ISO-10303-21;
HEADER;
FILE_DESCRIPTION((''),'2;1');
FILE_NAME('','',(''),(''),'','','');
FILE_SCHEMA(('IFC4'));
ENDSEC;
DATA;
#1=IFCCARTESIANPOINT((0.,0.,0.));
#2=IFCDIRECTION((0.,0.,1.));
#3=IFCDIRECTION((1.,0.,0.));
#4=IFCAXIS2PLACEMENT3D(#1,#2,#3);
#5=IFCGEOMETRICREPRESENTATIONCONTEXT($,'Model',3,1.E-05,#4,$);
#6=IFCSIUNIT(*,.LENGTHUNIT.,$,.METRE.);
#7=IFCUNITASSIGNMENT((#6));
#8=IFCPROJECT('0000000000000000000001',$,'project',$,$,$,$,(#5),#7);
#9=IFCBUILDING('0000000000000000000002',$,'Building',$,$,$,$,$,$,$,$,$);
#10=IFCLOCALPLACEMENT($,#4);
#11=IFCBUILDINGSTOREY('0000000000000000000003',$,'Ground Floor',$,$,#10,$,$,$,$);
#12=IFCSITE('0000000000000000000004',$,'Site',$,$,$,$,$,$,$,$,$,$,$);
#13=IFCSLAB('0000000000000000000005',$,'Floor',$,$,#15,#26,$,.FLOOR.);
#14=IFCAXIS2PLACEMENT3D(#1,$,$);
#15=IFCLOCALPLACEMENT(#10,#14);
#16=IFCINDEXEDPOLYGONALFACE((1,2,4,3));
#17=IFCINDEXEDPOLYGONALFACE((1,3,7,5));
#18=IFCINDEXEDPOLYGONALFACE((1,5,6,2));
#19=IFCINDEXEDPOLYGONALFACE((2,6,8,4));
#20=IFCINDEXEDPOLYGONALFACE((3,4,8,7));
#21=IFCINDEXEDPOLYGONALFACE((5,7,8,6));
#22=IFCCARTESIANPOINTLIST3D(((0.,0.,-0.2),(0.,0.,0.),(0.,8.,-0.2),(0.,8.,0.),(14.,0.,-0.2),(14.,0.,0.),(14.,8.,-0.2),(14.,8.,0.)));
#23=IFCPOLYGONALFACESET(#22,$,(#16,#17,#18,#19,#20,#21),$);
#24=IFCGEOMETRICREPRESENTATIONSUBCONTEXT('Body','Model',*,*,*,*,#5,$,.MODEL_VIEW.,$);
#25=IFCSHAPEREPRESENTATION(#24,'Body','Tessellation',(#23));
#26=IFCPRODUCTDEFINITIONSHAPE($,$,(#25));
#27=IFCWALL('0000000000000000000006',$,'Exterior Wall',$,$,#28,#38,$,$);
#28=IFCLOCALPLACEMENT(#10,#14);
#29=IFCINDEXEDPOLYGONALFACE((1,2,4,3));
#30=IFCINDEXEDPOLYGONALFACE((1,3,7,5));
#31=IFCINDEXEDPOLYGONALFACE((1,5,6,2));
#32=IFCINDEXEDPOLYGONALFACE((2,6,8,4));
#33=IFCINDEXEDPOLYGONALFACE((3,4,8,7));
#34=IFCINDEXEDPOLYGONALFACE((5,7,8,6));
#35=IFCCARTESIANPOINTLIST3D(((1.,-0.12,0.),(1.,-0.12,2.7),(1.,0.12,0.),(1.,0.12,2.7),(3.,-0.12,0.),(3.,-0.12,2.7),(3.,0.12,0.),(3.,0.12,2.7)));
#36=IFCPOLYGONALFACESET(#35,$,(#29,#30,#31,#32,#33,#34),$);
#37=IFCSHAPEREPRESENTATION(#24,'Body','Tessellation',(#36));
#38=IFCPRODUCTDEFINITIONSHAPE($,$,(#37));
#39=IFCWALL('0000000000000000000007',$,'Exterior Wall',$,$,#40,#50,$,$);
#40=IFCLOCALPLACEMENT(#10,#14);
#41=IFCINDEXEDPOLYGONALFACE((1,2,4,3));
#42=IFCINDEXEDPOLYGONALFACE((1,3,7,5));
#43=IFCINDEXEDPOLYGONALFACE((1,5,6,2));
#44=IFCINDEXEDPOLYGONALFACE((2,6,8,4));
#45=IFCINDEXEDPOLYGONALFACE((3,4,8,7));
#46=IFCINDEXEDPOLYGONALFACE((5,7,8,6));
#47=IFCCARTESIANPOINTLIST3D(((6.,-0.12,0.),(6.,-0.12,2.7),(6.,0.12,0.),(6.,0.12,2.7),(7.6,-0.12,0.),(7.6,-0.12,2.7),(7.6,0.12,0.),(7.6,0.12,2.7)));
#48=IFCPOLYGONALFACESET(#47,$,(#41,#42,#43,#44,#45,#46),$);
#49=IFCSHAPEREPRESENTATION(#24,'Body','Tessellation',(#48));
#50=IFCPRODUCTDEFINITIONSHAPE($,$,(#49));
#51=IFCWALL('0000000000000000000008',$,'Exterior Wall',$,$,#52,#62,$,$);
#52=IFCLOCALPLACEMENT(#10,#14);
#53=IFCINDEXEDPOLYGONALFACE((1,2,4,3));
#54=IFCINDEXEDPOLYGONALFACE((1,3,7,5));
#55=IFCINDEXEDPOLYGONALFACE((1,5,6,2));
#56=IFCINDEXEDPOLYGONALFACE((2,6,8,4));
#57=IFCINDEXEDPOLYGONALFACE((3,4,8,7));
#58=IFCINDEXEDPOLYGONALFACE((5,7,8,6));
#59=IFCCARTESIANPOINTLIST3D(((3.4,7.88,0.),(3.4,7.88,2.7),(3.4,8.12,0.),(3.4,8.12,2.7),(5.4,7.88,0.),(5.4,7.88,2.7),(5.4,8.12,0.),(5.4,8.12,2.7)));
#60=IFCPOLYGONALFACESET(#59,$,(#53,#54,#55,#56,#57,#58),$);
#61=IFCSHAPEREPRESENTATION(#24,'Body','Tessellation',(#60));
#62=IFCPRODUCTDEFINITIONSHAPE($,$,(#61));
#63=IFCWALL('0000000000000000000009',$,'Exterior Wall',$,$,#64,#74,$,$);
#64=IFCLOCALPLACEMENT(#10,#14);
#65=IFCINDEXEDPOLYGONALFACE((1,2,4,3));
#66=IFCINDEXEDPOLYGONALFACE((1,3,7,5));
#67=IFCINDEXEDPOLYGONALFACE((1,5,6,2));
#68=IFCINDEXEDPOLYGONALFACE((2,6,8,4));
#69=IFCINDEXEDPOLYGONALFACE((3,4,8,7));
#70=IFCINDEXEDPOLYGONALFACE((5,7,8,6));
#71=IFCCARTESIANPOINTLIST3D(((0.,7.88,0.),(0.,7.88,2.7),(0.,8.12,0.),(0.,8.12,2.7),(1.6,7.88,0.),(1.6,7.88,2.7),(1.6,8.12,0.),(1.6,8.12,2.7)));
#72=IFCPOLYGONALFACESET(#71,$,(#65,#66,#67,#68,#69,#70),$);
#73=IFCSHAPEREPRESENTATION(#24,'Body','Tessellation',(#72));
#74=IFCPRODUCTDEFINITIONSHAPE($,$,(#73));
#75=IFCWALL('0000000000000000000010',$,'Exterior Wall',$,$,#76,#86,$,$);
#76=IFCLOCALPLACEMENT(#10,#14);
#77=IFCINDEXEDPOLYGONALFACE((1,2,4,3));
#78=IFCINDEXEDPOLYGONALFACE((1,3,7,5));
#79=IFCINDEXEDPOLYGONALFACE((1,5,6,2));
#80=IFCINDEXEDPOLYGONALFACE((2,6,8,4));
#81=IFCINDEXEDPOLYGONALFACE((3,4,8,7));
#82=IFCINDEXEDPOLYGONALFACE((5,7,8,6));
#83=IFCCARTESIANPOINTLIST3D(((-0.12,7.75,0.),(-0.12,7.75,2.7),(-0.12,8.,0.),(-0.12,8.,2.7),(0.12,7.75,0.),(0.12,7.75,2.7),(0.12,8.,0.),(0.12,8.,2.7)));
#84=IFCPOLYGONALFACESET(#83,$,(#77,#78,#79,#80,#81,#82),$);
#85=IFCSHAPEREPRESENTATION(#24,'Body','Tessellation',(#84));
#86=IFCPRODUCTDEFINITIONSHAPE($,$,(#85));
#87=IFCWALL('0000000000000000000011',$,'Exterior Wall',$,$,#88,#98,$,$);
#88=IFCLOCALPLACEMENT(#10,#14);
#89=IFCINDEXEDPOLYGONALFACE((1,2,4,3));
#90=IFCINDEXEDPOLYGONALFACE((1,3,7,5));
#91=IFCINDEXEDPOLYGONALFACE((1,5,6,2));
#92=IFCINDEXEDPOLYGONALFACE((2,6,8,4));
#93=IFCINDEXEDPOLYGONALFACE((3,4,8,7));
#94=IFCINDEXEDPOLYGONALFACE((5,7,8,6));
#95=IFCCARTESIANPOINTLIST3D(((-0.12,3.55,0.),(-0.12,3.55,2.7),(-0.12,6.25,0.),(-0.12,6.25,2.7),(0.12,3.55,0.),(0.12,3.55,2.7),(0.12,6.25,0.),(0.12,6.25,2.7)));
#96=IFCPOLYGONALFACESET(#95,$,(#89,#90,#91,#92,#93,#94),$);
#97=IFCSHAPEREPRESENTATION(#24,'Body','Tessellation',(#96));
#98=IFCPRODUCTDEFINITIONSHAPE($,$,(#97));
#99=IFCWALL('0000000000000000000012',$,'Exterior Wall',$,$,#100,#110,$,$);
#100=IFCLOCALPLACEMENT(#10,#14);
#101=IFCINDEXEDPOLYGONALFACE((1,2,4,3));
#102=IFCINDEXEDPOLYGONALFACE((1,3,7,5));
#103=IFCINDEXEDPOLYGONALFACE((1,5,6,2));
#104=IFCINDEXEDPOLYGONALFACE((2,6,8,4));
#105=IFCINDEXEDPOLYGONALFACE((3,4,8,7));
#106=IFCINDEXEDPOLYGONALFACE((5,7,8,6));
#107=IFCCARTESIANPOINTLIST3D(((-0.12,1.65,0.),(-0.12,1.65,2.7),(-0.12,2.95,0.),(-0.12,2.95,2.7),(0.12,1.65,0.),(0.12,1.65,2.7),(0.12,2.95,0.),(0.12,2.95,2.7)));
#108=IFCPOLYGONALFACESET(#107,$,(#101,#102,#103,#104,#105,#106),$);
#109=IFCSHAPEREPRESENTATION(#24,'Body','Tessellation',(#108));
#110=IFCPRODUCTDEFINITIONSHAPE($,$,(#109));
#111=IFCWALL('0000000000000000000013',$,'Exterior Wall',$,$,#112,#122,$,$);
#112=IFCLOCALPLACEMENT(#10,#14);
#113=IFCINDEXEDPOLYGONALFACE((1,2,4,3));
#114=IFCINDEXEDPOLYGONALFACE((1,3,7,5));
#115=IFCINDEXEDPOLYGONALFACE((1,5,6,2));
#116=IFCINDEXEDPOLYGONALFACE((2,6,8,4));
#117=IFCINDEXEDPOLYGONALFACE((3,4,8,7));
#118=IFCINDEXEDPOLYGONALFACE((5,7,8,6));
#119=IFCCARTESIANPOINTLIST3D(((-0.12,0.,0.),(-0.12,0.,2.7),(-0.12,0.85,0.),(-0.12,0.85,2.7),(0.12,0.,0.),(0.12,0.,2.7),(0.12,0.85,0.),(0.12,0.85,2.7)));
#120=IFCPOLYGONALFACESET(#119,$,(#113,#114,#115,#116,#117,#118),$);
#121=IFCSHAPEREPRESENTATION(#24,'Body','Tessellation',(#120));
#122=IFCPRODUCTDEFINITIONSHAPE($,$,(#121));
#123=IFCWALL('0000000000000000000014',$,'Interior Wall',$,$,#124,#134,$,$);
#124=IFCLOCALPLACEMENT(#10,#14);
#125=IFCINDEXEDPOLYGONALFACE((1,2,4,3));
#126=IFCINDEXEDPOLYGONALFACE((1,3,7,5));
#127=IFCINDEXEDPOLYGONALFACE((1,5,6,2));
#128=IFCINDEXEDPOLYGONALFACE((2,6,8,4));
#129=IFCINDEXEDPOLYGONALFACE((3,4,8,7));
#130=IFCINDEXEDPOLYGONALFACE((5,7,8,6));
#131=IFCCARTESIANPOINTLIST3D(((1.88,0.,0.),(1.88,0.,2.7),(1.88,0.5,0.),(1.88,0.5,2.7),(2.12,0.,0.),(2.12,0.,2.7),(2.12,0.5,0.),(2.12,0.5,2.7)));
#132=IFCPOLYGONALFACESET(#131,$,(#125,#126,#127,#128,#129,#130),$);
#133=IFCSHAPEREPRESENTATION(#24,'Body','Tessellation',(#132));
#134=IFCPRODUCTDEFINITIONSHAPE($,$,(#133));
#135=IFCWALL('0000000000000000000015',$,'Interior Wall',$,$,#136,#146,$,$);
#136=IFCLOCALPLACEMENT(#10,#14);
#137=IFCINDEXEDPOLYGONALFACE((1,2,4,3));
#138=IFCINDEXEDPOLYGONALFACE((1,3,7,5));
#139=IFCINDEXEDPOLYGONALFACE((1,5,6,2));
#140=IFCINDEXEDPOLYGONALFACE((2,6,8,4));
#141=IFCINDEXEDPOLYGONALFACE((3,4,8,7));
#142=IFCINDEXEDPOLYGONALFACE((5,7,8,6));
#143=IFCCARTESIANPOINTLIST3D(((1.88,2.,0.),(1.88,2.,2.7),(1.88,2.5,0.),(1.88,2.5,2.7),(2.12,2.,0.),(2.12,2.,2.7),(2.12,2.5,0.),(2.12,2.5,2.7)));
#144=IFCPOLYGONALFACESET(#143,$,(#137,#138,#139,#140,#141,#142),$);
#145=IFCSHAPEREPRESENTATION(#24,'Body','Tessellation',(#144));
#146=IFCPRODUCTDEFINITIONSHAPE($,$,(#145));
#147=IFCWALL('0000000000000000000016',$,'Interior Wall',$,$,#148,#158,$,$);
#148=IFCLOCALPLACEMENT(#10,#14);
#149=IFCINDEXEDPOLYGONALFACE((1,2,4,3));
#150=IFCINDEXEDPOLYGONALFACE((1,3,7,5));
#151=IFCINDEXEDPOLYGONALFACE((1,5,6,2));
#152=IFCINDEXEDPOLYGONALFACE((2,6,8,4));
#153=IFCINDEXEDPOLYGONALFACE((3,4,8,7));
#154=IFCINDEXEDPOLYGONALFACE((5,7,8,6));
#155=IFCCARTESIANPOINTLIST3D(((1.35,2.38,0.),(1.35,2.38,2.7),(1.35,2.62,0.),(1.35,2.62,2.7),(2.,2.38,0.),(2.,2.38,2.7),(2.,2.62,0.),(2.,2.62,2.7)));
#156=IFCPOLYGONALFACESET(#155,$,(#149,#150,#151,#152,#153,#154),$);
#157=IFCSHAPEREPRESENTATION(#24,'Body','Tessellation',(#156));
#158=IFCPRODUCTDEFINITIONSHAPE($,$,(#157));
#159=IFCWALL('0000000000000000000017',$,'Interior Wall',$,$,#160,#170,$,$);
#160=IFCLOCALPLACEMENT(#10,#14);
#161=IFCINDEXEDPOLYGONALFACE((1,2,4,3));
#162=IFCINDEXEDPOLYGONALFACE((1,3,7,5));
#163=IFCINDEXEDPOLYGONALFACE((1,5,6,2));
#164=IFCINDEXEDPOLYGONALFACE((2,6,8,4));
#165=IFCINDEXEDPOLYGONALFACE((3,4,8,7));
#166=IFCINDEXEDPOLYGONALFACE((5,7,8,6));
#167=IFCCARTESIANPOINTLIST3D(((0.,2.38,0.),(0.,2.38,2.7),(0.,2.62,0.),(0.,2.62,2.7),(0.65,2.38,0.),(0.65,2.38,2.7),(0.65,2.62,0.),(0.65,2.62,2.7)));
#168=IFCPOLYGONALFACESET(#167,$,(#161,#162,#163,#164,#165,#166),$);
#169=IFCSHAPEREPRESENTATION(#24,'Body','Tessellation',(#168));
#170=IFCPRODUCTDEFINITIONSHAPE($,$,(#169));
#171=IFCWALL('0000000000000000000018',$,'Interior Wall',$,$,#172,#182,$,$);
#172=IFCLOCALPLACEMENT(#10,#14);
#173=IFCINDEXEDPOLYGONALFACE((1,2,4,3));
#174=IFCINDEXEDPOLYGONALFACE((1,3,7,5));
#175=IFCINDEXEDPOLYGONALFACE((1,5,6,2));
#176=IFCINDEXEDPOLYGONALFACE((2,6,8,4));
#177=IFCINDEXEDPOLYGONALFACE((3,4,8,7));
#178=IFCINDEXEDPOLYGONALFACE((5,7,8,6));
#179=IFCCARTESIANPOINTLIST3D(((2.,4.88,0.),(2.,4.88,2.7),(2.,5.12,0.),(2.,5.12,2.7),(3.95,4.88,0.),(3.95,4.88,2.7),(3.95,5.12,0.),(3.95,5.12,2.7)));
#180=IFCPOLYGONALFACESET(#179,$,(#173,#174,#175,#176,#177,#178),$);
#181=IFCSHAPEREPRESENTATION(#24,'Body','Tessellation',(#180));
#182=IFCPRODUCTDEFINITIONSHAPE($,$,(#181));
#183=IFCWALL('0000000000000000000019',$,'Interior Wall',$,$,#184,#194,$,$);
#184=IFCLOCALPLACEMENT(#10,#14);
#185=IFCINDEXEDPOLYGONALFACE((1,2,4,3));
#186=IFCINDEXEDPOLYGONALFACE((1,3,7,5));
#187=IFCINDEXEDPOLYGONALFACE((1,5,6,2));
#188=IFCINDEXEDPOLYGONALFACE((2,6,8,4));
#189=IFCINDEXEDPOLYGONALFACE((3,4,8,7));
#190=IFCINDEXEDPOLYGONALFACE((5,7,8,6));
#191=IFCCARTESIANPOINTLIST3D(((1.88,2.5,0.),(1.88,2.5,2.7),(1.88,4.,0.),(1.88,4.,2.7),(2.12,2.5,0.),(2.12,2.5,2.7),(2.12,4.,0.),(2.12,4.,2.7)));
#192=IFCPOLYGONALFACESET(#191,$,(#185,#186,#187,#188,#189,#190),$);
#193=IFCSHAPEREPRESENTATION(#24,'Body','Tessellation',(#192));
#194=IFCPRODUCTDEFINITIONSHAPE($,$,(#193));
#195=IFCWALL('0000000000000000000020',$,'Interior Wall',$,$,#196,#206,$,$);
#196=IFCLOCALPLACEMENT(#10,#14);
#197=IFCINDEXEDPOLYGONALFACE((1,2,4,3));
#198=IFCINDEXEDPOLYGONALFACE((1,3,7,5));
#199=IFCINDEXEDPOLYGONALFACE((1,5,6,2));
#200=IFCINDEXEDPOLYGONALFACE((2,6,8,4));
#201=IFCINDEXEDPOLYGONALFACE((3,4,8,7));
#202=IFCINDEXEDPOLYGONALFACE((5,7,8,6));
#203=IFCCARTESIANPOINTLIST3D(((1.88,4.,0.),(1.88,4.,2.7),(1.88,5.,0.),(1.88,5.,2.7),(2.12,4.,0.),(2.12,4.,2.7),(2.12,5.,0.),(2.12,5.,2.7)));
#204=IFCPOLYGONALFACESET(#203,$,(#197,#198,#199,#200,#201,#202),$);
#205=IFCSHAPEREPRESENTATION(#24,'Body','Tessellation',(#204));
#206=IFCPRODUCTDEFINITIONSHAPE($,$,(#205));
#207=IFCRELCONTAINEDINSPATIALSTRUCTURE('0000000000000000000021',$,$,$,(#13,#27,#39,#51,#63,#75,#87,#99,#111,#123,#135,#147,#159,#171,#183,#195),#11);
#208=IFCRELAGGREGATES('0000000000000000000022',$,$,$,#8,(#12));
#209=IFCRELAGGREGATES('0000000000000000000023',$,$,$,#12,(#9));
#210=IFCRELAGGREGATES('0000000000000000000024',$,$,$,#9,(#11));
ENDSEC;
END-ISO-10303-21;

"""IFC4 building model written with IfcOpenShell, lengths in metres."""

from ifc_helpers import new_model, si_unit, frame, origin_with_axes, place, context, subcontext, project, spatial, indexed_curve, outline, extrude, element, save


model = new_model("IFC4")

# Units and contexts
model_context = context("Model", 3, precision=1e-05, world=origin_with_axes())
body_context = subcontext(model_context, "Body", "Model", "MODEL_VIEW")
ifc_project = project(units=[si_unit("LENGTHUNIT", "METRE")], contexts=[model_context])

# Site, building, storey
site = spatial("IfcSite", under=ifc_project, Name="Site")
building = spatial("IfcBuilding", under=site, Name="Building")
storey_placement = place(None, origin_with_axes())
storey = spatial("IfcBuildingStorey", under=building, at=storey_placement, Name="Ground Floor")

# Slab
slab_placement = place(storey_placement, frame((0.0, 0.0, -0.2), z_axis=(0.0, 0.0, 1.0), x_axis=(1.0, 0.0, 0.0)))
element("IfcSlab", 1, at=slab_placement, inside=storey, Name="Floor", PredefinedType="FLOOR", context=body_context, shape_type="SweptSolid", body=[
    extrude(outline(indexed_curve([(0.0, 0.0), (14.0, 0.0), (14.0, 8.0), (0.0, 8.0)])), None, (0.0, 0.0, 1.0), 0.2),
])

# Walls
wall_1_placement = place(storey_placement, frame((1.0, 0.0, 0.0), z_axis=(0.0, 0.0, 1.0), x_axis=(1.0, 0.0, 0.0)))
element("IfcWall", 2, at=wall_1_placement, inside=storey, Name="Exterior Wall", context=body_context, shape_type="SweptSolid", body=[
    extrude(outline(indexed_curve([(0.0, 0.0), (0.0, 0.24), (2.0, 0.24), (2.0, 0.0), (0.0, 0.0)], self_intersect=False)), frame((0.0, -0.12, 0.0), z_axis=(0.0, 0.0, 1.0), x_axis=(1.0, 0.0, 0.0)), (0.0, 0.0, 1.0), 2.7),
])
wall_2_placement = place(storey_placement, frame((6.0, 0.0, 0.0), z_axis=(0.0, 0.0, 1.0), x_axis=(1.0, 0.0, 0.0)))
element("IfcWall", 3, at=wall_2_placement, inside=storey, Name="Exterior Wall", context=body_context, shape_type="SweptSolid", body=[
    extrude(outline(indexed_curve([(0.0, 0.0), (0.0, 0.24), (1.6, 0.24), (1.6, 0.0), (0.0, 0.0)], self_intersect=False)), frame((0.0, -0.12, 0.0), z_axis=(0.0, 0.0, 1.0), x_axis=(1.0, 0.0, 0.0)), (0.0, 0.0, 1.0), 2.7),
])
wall_3_placement = place(storey_placement, frame((5.4, 8.0, 0.0), z_axis=(0.0, 0.0, 1.0), x_axis=(-1.0, 0.0, 0.0)))
element("IfcWall", 4, at=wall_3_placement, inside=storey, Name="Exterior Wall", context=body_context, shape_type="SweptSolid", body=[
    extrude(outline(indexed_curve([(0.0, 0.0), (0.0, 0.24), (2.0, 0.24), (2.0, 0.0), (0.0, 0.0)], self_intersect=False)), frame((0.0, -0.12, 0.0), z_axis=(0.0, 0.0, 1.0), x_axis=(1.0, 0.0, 0.0)), (0.0, 0.0, 1.0), 2.7),
])
wall_4_placement = place(storey_placement, frame((1.6, 8.0, 0.0), z_axis=(0.0, 0.0, 1.0), x_axis=(-1.0, 0.0, 0.0)))
element("IfcWall", 5, at=wall_4_placement, inside=storey, Name="Exterior Wall", context=body_context, shape_type="SweptSolid", body=[
    extrude(outline(indexed_curve([(0.0, 0.0), (0.0, 0.24), (1.6, 0.24), (1.6, 0.0), (0.0, 0.0)], self_intersect=False)), frame((0.0, -0.12, 0.0), z_axis=(0.0, 0.0, 1.0), x_axis=(1.0, 0.0, 0.0)), (0.0, 0.0, 1.0), 2.7),
])
wall_5_placement = place(storey_placement, frame((0.0, 8.0, 0.0), z_axis=(0.0, 0.0, 1.0), x_axis=(0.0, -1.0, 0.0)))
element("IfcWall", 6, at=wall_5_placement, inside=storey, Name="Exterior Wall", context=body_context, shape_type="SweptSolid", body=[
    extrude(outline(indexed_curve([(0.0, 0.0), (0.0, 0.24), (0.25, 0.24), (0.25, 0.0), (0.0, 0.0)], self_intersect=False)), frame((0.0, -0.12, 0.0), z_axis=(0.0, 0.0, 1.0), x_axis=(1.0, 0.0, 0.0)), (0.0, 0.0, 1.0), 2.7),
])
wall_6_placement = place(storey_placement, frame((0.0, 6.25, 0.0), z_axis=(0.0, 0.0, 1.0), x_axis=(0.0, -1.0, 0.0)))
element("IfcWall", 7, at=wall_6_placement, inside=storey, Name="Exterior Wall", context=body_context, shape_type="SweptSolid", body=[
    extrude(outline(indexed_curve([(0.0, 0.0), (0.0, 0.24), (2.7, 0.24), (2.7, 0.0), (0.0, 0.0)], self_intersect=False)), frame((0.0, -0.12, 0.0), z_axis=(0.0, 0.0, 1.0), x_axis=(1.0, 0.0, 0.0)), (0.0, 0.0, 1.0), 2.7),
])
wall_7_placement = place(storey_placement, frame((0.0, 2.95, 0.0), z_axis=(0.0, 0.0, 1.0), x_axis=(0.0, -1.0, 0.0)))
element("IfcWall", 8, at=wall_7_placement, inside=storey, Name="Exterior Wall", context=body_context, shape_type="SweptSolid", body=[
    extrude(outline(indexed_curve([(0.0, 0.0), (0.0, 0.24), (1.3, 0.24), (1.3, 0.0), (0.0, 0.0)], self_intersect=False)), frame((0.0, -0.12, 0.0), z_axis=(0.0, 0.0, 1.0), x_axis=(1.0, 0.0, 0.0)), (0.0, 0.0, 1.0), 2.7),
])
wall_8_placement = place(storey_placement, frame((0.0, 0.85, 0.0), z_axis=(0.0, 0.0, 1.0), x_axis=(0.0, -1.0, 0.0)))
element("IfcWall", 9, at=wall_8_placement, inside=storey, Name="Exterior Wall", context=body_context, shape_type="SweptSolid", body=[
    extrude(outline(indexed_curve([(0.0, 0.0), (0.0, 0.24), (0.85, 0.24), (0.85, 0.0), (0.0, 0.0)], self_intersect=False)), frame((0.0, -0.12, 0.0), z_axis=(0.0, 0.0, 1.0), x_axis=(1.0, 0.0, 0.0)), (0.0, 0.0, 1.0), 2.7),
])
for number, where, z_axis, x_axis, name in (
    (10, (2.0, 0.0, 0.0), (0.0, 0.0, 1.0), (0.0, 1.0, 0.0), "Interior Wall"),
    (11, (2.0, 2.0, 0.0), (0.0, 0.0, 1.0), (0.0, 1.0, 0.0), "Interior Wall"),
):
    element("IfcWall", number, at=place(storey_placement, frame(where, z_axis=z_axis, x_axis=x_axis)), inside=storey, Name=name, context=body_context, shape_type="SweptSolid", body=[
        extrude(outline(indexed_curve([(0.0, 0.0), (0.0, 0.24), (0.5, 0.24), (0.5, 0.0), (0.0, 0.0)], self_intersect=False)), frame((0.0, -0.12, 0.0), z_axis=(0.0, 0.0, 1.0), x_axis=(1.0, 0.0, 0.0)), (0.0, 0.0, 1.0), 2.7),
    ])
for number, where, z_axis, x_axis, name in (
    (12, (2.0, 2.5, 0.0), (0.0, 0.0, 1.0), (-1.0, 0.0, 0.0), "Interior Wall"),
    (13, (0.65, 2.5, 0.0), (0.0, 0.0, 1.0), (-1.0, 0.0, 0.0), "Interior Wall"),
):
    element("IfcWall", number, at=place(storey_placement, frame(where, z_axis=z_axis, x_axis=x_axis)), inside=storey, Name=name, context=body_context, shape_type="SweptSolid", body=[
        extrude(outline(indexed_curve([(0.0, 0.0), (0.0, 0.24), (0.65, 0.24), (0.65, 0.0), (0.0, 0.0)], self_intersect=False)), frame((0.0, -0.12, 0.0), z_axis=(0.0, 0.0, 1.0), x_axis=(1.0, 0.0, 0.0)), (0.0, 0.0, 1.0), 2.7),
    ])
wall_9_placement = place(storey_placement, frame((3.95, 5.0, 0.0), z_axis=(0.0, 0.0, 1.0), x_axis=(-1.0, 0.0, 0.0)))
element("IfcWall", 14, at=wall_9_placement, inside=storey, Name="Interior Wall", context=body_context, shape_type="SweptSolid", body=[
    extrude(outline(indexed_curve([(0.0, 0.0), (0.0, 0.24), (1.95, 0.24), (1.95, 0.0), (0.0, 0.0)], self_intersect=False)), frame((0.0, -0.12, 0.0), z_axis=(0.0, 0.0, 1.0), x_axis=(1.0, 0.0, 0.0)), (0.0, 0.0, 1.0), 2.7),
])
wall_10_placement = place(storey_placement, frame((2.0, 4.0, 0.0), z_axis=(0.0, 0.0, 1.0), x_axis=(0.0, -1.0, 0.0)))
element("IfcWall", 15, at=wall_10_placement, inside=storey, Name="Interior Wall", context=body_context, shape_type="SweptSolid", body=[
    extrude(outline(indexed_curve([(0.0, 0.0), (0.0, 0.24), (1.5, 0.24), (1.5, 0.0), (0.0, 0.0)], self_intersect=False)), frame((0.0, -0.12, 0.0), z_axis=(0.0, 0.0, 1.0), x_axis=(1.0, 0.0, 0.0)), (0.0, 0.0, 1.0), 2.7),
])
wall_11_placement = place(storey_placement, frame((2.0, 5.0, 0.0), z_axis=(0.0, 0.0, 1.0), x_axis=(0.0, -1.0, 0.0)))
element("IfcWall", 16, at=wall_11_placement, inside=storey, Name="Interior Wall", context=body_context, shape_type="SweptSolid", body=[
    extrude(outline(indexed_curve([(0.0, 0.0), (0.0, 0.24), (1.0, 0.24), (1.0, 0.0), (0.0, 0.0)], self_intersect=False)), frame((0.0, -0.12, 0.0), z_axis=(0.0, 0.0, 1.0), x_axis=(1.0, 0.0, 0.0)), (0.0, 0.0, 1.0), 2.7),
])

save(model, "model.ifc")
